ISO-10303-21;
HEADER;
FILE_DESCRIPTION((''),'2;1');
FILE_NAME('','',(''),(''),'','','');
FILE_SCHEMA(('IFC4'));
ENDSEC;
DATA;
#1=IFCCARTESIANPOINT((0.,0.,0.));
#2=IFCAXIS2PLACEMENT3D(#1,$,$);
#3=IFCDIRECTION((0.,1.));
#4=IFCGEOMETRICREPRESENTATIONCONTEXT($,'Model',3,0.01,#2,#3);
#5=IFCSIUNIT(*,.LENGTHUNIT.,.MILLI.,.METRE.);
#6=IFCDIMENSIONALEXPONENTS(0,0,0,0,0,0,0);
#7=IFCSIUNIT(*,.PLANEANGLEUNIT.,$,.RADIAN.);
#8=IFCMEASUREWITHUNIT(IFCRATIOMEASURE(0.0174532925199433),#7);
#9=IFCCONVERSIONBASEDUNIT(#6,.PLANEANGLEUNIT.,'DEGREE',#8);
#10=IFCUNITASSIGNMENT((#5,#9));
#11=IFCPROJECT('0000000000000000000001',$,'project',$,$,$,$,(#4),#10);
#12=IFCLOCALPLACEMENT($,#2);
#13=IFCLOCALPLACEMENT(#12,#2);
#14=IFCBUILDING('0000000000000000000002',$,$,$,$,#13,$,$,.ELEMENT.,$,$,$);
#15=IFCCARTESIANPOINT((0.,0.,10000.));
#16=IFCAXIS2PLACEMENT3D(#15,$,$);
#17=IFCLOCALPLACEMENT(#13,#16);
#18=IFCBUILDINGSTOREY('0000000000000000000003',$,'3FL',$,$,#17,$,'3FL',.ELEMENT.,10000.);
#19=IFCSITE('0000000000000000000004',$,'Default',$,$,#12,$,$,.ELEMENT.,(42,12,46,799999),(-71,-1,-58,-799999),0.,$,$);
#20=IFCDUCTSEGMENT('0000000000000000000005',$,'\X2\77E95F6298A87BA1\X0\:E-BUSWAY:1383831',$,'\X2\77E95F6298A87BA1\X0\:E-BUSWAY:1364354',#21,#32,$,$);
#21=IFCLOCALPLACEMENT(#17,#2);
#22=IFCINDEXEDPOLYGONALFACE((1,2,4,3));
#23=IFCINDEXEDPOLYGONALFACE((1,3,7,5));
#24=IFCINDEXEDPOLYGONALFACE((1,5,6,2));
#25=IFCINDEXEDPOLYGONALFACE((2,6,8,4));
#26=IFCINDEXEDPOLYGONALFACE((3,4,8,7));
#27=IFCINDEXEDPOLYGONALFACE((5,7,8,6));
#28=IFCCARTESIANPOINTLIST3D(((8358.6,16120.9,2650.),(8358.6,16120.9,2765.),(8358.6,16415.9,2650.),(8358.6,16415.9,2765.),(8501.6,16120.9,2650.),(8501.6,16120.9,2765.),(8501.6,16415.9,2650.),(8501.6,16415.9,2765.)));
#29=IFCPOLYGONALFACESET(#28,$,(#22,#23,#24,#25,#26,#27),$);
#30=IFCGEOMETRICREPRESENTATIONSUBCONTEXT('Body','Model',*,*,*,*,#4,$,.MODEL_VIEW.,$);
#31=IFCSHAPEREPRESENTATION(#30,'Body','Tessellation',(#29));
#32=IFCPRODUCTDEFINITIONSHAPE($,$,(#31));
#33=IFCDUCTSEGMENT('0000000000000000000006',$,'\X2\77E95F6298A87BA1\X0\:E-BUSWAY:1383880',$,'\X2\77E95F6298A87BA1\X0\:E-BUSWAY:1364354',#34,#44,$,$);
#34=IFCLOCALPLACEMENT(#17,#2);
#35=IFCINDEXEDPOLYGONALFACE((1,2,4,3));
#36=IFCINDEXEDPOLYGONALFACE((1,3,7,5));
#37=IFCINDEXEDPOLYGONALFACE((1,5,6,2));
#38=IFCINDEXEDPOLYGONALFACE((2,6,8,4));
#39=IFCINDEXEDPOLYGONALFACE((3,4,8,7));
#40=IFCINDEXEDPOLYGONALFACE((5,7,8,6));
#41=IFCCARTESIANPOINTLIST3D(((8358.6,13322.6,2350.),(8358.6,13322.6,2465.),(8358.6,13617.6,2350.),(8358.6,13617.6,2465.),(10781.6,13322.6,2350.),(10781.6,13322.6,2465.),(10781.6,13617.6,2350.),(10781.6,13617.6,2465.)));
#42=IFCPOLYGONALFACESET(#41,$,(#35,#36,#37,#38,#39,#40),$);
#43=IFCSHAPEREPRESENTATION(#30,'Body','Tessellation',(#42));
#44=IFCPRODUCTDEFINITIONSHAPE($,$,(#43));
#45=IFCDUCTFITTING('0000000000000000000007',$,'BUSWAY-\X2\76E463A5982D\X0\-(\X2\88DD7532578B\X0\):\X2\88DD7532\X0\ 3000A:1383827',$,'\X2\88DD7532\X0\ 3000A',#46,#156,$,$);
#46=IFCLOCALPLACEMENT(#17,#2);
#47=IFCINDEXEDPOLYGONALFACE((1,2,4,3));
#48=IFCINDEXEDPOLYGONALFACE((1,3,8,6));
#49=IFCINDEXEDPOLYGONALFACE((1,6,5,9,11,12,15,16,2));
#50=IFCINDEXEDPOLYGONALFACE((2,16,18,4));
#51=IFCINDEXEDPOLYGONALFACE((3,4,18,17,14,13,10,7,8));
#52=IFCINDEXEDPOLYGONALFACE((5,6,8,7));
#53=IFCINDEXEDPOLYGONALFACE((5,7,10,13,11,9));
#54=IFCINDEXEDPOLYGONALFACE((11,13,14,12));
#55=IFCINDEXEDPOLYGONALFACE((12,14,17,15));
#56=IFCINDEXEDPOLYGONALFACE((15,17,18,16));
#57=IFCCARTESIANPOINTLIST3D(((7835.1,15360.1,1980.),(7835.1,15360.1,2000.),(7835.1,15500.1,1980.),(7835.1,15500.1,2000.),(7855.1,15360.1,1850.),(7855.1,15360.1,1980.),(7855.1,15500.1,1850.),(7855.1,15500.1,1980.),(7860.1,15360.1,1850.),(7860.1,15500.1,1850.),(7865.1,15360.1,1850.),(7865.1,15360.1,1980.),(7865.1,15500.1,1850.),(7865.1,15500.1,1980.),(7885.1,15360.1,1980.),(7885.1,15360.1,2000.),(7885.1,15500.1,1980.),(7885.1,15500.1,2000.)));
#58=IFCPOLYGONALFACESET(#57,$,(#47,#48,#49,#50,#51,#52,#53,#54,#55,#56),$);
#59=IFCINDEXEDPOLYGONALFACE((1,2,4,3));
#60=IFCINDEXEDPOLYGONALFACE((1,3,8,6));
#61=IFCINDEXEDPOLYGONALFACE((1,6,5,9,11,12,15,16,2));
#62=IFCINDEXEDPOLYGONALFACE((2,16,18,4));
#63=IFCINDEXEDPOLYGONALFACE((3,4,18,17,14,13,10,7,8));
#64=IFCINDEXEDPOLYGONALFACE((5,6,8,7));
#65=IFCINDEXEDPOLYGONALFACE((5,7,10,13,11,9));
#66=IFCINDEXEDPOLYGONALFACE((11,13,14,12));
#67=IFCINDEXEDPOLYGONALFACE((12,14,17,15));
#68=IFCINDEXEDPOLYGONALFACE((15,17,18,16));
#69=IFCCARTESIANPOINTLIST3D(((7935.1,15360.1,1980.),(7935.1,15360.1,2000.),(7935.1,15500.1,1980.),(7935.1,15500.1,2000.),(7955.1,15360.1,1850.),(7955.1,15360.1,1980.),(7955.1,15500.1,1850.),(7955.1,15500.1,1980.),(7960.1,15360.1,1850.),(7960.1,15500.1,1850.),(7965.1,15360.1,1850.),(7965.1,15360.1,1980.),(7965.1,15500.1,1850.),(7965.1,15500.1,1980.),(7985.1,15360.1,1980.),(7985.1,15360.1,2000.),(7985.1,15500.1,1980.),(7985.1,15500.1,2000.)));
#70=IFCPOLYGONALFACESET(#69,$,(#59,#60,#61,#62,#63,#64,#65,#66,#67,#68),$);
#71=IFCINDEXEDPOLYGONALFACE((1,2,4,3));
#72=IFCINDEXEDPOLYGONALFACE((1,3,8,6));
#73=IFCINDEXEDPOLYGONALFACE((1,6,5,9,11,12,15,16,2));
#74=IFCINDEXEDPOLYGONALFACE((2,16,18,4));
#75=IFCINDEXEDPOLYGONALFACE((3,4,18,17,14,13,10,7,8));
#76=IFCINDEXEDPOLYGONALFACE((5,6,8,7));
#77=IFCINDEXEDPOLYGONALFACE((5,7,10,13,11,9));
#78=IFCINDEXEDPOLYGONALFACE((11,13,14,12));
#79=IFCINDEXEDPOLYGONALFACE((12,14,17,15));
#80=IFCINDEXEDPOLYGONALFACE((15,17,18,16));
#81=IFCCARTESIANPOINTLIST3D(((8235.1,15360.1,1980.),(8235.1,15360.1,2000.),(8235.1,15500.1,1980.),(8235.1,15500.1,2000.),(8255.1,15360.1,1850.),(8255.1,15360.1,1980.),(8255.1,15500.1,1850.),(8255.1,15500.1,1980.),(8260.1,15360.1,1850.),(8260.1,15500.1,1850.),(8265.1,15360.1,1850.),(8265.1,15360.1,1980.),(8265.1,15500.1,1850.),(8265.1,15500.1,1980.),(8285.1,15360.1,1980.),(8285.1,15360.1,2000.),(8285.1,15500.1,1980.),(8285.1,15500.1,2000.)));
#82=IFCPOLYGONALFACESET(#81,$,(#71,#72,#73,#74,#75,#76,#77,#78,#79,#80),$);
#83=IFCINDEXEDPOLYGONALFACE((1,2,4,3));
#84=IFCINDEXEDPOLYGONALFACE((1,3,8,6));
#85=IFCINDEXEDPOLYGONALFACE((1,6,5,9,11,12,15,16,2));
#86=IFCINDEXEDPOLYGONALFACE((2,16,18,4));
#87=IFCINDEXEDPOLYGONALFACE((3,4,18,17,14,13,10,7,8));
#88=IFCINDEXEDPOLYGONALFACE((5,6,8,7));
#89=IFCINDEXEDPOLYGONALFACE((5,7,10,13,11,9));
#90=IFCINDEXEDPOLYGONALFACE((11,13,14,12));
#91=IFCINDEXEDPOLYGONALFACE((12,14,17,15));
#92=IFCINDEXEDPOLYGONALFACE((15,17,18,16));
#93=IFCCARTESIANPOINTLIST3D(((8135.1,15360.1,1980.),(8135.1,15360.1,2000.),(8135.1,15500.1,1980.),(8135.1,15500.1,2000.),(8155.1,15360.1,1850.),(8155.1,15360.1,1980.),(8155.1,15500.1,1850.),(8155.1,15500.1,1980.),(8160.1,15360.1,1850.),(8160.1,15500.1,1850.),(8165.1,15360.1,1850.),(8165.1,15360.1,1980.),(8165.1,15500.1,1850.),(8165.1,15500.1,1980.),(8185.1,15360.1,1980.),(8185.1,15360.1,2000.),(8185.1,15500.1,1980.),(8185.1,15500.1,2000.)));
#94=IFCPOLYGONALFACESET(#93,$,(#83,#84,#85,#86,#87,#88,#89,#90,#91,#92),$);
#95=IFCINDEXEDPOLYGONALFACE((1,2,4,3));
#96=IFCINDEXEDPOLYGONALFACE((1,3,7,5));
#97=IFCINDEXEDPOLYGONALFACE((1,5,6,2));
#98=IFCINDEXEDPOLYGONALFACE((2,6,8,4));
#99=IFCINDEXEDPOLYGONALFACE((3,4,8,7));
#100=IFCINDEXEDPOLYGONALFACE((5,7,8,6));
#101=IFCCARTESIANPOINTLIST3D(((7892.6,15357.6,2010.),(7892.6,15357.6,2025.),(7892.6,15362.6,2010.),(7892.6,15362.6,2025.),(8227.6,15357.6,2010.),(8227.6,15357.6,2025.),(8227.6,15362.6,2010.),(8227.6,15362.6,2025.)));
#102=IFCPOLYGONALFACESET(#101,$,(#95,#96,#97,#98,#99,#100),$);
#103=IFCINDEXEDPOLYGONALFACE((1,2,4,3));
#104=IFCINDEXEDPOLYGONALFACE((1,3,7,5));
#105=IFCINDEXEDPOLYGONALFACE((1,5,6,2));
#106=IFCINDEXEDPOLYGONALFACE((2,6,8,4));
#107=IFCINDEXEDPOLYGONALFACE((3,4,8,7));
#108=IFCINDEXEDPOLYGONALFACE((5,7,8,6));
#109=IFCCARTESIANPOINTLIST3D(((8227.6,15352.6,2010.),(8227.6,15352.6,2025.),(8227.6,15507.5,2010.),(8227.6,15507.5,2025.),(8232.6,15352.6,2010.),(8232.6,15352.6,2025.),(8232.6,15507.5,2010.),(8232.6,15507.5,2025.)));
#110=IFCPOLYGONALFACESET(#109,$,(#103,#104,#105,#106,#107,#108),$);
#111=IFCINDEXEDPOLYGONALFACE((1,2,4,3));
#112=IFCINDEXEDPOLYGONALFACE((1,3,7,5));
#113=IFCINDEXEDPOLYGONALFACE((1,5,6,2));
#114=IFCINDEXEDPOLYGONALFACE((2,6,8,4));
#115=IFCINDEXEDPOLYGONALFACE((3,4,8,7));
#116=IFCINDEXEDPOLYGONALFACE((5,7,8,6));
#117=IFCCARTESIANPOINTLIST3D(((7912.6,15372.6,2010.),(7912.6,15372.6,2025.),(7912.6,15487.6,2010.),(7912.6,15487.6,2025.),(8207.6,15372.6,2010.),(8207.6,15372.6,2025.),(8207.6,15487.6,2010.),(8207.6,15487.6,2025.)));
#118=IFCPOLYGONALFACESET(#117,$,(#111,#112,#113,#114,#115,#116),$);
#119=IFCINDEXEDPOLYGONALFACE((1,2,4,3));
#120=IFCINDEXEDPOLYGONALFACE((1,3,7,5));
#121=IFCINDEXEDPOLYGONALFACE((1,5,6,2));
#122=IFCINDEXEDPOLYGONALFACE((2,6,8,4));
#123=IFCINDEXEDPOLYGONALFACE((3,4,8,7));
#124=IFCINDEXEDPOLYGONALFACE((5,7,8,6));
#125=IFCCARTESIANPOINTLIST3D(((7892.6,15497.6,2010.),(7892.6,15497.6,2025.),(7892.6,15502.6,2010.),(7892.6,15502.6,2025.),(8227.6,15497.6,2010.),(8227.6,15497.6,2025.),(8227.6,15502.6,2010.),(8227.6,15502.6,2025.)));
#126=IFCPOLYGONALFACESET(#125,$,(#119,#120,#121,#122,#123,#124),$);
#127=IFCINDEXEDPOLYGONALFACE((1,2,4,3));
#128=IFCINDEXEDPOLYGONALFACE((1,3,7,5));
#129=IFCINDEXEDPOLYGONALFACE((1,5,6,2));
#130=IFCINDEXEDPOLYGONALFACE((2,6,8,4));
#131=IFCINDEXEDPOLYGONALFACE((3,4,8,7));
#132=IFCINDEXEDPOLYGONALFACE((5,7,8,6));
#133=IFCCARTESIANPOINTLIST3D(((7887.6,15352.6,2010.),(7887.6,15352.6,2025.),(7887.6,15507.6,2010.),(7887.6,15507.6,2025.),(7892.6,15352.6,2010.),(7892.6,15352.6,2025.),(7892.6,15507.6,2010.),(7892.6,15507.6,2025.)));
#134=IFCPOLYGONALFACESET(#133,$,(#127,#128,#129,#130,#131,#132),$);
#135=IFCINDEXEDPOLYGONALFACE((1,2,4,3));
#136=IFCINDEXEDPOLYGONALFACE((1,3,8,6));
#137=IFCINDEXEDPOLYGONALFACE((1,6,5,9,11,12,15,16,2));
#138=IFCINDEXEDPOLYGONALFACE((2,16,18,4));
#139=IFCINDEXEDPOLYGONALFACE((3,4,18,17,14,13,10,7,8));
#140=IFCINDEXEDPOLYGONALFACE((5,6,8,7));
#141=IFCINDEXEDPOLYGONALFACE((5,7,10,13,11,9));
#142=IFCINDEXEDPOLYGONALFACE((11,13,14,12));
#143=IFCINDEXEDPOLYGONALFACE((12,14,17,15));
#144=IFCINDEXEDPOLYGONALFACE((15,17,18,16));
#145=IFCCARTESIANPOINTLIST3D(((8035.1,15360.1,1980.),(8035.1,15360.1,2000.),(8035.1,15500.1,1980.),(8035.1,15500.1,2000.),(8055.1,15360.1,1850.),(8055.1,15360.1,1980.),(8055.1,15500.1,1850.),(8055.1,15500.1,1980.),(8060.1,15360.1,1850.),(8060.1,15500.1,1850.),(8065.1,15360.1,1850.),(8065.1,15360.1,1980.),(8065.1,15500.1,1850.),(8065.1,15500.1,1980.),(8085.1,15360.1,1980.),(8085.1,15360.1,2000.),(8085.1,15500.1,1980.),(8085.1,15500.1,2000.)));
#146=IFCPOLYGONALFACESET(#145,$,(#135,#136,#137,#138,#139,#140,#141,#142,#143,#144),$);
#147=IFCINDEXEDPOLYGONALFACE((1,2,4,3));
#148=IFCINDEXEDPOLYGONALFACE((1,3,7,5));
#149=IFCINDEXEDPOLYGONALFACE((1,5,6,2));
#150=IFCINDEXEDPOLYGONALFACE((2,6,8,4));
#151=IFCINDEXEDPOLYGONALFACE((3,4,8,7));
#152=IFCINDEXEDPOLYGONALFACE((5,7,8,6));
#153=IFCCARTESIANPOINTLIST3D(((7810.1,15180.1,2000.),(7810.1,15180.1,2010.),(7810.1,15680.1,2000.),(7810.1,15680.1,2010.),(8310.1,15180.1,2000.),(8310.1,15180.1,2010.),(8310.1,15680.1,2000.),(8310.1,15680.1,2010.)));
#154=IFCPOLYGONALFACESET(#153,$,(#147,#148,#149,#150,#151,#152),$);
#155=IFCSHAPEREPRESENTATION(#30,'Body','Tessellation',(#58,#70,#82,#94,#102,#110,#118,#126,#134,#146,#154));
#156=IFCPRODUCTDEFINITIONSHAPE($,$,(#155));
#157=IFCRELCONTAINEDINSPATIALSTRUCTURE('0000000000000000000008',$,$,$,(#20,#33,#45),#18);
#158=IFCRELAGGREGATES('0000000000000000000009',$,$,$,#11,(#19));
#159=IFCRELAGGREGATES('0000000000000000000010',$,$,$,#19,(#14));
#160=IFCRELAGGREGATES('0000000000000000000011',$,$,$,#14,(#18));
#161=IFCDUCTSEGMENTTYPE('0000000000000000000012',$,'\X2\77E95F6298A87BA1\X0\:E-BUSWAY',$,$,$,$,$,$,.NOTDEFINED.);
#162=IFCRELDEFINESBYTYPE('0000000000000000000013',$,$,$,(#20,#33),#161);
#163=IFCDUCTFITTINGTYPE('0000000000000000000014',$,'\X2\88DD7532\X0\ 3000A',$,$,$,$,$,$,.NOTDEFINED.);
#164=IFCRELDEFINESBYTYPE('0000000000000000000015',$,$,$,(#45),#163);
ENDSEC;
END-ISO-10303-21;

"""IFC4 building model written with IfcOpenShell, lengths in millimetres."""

from ifc_helpers import new_model, entity, si_unit, converted_unit, direction, frame, frame_2d, origin, origin_2d_with_axis, place, context, subcontext, project, spatial, polyline, rectangle, outline, extrude, source, transform, mapped, type_object, type_shapes, element, save


model = new_model("IFC4")

# Units and contexts
model_context = context("Model", 3, precision=0.01, world=origin(), true_north=direction((0.0, 1.0)))
body_context = subcontext(model_context, "Body", "Model", "MODEL_VIEW")
ifc_project = project(units=[si_unit("LENGTHUNIT", "METRE", prefix="MILLI"), converted_unit("PLANEANGLEUNIT", "DEGREE", entity("IfcRatioMeasure", 0.0174532925199433), si_unit("PLANEANGLEUNIT", "RADIAN"), dimensions=[0, 0, 0, 0, 0, 0, 0])], contexts=[model_context])

# Site, building, storey
site_placement = place(None, origin())
site = spatial("IfcSite", under=ifc_project, at=site_placement, Name="Default", CompositionType="ELEMENT", RefLatitude=(42, 12, 46, 799999), RefLongitude=(-71, -1, -58, -799999), RefElevation=0.0)
building_placement = place(site_placement, origin())
building = spatial("IfcBuilding", under=site, at=building_placement, CompositionType="ELEMENT")
storey_placement = place(building_placement, frame((0.0, 0.0, 10000.0)))
storey = spatial("IfcBuildingStorey", under=building, at=storey_placement, Name="3FL", LongName="3FL", CompositionType="ELEMENT", Elevation=10000.0)

# Duct segments
duct_segment_type = type_object("IfcDuctSegmentType", Name="矩形風管:E-BUSWAY", PredefinedType="NOTDEFINED")
duct_segment_1_placement = place(storey_placement, frame((8358.6, 16120.9, 2650.0)))
element("IfcDuctSegment", 1, at=duct_segment_1_placement, inside=storey, type_object=duct_segment_type, Name="矩形風管:E-BUSWAY:1383831", ObjectType="矩形風管:E-BUSWAY:1364354", context=body_context, shape_type="SweptSolid", body=[
    extrude(rectangle(XDim=143.0, YDim=295.0, at=frame_2d((0.0, 0.0), x_axis=(1.0, 0.0))), frame((71.5, 147.5, 0.0)), (0.0, 0.0, 1.0), 115.0),
])
duct_segment_2_placement = place(storey_placement, frame((8358.6, 13322.6, 2350.0)))
element("IfcDuctSegment", 2, at=duct_segment_2_placement, inside=storey, type_object=duct_segment_type, Name="矩形風管:E-BUSWAY:1383880", ObjectType="矩形風管:E-BUSWAY:1364354", context=body_context, shape_type="SweptSolid", body=[
    extrude(rectangle(XDim=2423.0, YDim=295.0, at=frame_2d((0.0, 0.0), x_axis=(1.0, 0.0))), frame((1211.5, 147.5, 0.0), z_axis=(0.0, 0.0, 1.0), x_axis=(-1.0, 0.0, 0.0)), (0.0, 0.0, 1.0), 115.0),
])

# Duct fitting
duct_fitting_type_1 = type_object("IfcDuctFittingType", Name="裝甲 3000A", PredefinedType="NOTDEFINED")
shared_shape_1 = source(origin(), body_context, "Body", "SweptSolid", [
    extrude(outline(polyline([(-25.0, -58.9), (25.0, -58.9), (25.0, -38.9), (5.0, -38.9), (5.0, 91.1), (0.0, 91.1), (-5.0, 91.1), (-5.0, -38.9), (-25.0, -38.9), (-25.0, -58.9)])), frame((-200.0, -70.0, -58.9), z_axis=(0.0, 1.0, 0.0), x_axis=(1.0, 0.0, 0.0)), (0.0, 0.0, 1.0), 140.0),
    extrude(outline(polyline([(-25.0, -58.9), (25.0, -58.9), (25.0, -38.9), (5.0, -38.9), (5.0, 91.1), (0.0, 91.1), (-5.0, 91.1), (-5.0, -38.9), (-25.0, -38.9), (-25.0, -58.9)])), frame((-100.0, -70.0, -58.9), z_axis=(0.0, 1.0, 0.0), x_axis=(1.0, 0.0, 0.0)), (0.0, 0.0, 1.0), 140.0),
    extrude(outline(polyline([(-58.9, -25.0), (-38.9, -25.0), (-38.9, -5.0), (91.1, -5.0), (91.1, 0.0), (91.1, 5.0), (-38.9, 5.0), (-38.9, 25.0), (-58.9, 25.0), (-58.9, -25.0)])), frame((200.0, -70.0, -58.9), z_axis=(0.0, 1.0, 0.0), x_axis=(0.0, 0.0, -1.0)), (0.0, 0.0, 1.0), 140.0),
    extrude(outline(polyline([(-58.9, -25.0), (-38.9, -25.0), (-38.9, -5.0), (91.1, -5.0), (91.1, 0.0), (91.1, 5.0), (-38.9, 5.0), (-38.9, 25.0), (-58.9, 25.0), (-58.9, -25.0)])), frame((100.0, -70.0, -58.9), z_axis=(0.0, 1.0, 0.0), x_axis=(0.0, 0.0, -1.0)), (0.0, 0.0, 1.0), 140.0),
    extrude(rectangle(XDim=335.0, YDim=5.0, at=origin_2d_with_axis()), frame((0.0, -70.0, 10.0), z_axis=(0.0, 0.0, 1.0), x_axis=(-1.0, 0.0, 0.0)), (0.0, 0.0, 1.0), 15.0),
    extrude(rectangle(XDim=5.0, YDim=154.9, at=frame_2d((0.0, 0.0), x_axis=(1.0, 0.0))), frame((170.0, -0.1, 10.0), z_axis=(0.0, 0.0, 1.0), x_axis=(-1.0, 0.0, 0.0)), (0.0, 0.0, 1.0), 15.0),
    extrude(rectangle(XDim=295.0, YDim=115.0, at=origin_2d_with_axis()), frame((0.0, 0.0, 10.0), z_axis=(0.0, 0.0, 1.0), x_axis=(-1.0, 0.0, 0.0)), (0.0, 0.0, 1.0), 15.0),
    extrude(rectangle(XDim=335.0, YDim=5.0, at=origin_2d_with_axis()), frame((0.0, 70.0, 10.0), z_axis=(0.0, 0.0, 1.0), x_axis=(-1.0, 0.0, 0.0)), (0.0, 0.0, 1.0), 15.0),
    extrude(rectangle(XDim=5.0, YDim=155.0, at=origin_2d_with_axis()), frame((-170.0, 0.0, 10.0), z_axis=(0.0, 0.0, 1.0), x_axis=(-1.0, 0.0, 0.0)), (0.0, 0.0, 1.0), 15.0),
    extrude(outline(polyline([(-58.9, -25.0), (-38.9, -25.0), (-38.9, -5.0), (91.1, -5.0), (91.1, 0.0), (91.1, 5.0), (-38.9, 5.0), (-38.9, 25.0), (-58.9, 25.0), (-58.9, -25.0)])), frame((0.0, -70.0, -58.9), z_axis=(0.0, 1.0, 0.0), x_axis=(0.0, 0.0, -1.0)), (0.0, 0.0, 1.0), 140.0),
    extrude(rectangle(XDim=500.0, YDim=500.0, at=origin_2d_with_axis()), frame((0.0, 0.0, 0.0), z_axis=(0.0, 0.0, 1.0), x_axis=(0.0, 1.0, 0.0)), (0.0, 0.0, 1.0), 10.0),
])
type_shapes(duct_fitting_type_1, [shared_shape_1])
duct_fitting_1_placement = place(storey_placement, frame((8060.1, 15430.1, 2000.0)))
element("IfcDuctFitting", 3, at=duct_fitting_1_placement, inside=storey, type_object=duct_fitting_type_1, Name="BUSWAY-盤接頭-(裝甲型):裝甲 3000A:1383827", ObjectType="裝甲 3000A", context=body_context, shape_type="MappedRepresentation", body=[
    mapped(shared_shape_1, transform((0.0, 0.0, 0.0), scale=1.0)),
])

save(model, "model.ifc")
